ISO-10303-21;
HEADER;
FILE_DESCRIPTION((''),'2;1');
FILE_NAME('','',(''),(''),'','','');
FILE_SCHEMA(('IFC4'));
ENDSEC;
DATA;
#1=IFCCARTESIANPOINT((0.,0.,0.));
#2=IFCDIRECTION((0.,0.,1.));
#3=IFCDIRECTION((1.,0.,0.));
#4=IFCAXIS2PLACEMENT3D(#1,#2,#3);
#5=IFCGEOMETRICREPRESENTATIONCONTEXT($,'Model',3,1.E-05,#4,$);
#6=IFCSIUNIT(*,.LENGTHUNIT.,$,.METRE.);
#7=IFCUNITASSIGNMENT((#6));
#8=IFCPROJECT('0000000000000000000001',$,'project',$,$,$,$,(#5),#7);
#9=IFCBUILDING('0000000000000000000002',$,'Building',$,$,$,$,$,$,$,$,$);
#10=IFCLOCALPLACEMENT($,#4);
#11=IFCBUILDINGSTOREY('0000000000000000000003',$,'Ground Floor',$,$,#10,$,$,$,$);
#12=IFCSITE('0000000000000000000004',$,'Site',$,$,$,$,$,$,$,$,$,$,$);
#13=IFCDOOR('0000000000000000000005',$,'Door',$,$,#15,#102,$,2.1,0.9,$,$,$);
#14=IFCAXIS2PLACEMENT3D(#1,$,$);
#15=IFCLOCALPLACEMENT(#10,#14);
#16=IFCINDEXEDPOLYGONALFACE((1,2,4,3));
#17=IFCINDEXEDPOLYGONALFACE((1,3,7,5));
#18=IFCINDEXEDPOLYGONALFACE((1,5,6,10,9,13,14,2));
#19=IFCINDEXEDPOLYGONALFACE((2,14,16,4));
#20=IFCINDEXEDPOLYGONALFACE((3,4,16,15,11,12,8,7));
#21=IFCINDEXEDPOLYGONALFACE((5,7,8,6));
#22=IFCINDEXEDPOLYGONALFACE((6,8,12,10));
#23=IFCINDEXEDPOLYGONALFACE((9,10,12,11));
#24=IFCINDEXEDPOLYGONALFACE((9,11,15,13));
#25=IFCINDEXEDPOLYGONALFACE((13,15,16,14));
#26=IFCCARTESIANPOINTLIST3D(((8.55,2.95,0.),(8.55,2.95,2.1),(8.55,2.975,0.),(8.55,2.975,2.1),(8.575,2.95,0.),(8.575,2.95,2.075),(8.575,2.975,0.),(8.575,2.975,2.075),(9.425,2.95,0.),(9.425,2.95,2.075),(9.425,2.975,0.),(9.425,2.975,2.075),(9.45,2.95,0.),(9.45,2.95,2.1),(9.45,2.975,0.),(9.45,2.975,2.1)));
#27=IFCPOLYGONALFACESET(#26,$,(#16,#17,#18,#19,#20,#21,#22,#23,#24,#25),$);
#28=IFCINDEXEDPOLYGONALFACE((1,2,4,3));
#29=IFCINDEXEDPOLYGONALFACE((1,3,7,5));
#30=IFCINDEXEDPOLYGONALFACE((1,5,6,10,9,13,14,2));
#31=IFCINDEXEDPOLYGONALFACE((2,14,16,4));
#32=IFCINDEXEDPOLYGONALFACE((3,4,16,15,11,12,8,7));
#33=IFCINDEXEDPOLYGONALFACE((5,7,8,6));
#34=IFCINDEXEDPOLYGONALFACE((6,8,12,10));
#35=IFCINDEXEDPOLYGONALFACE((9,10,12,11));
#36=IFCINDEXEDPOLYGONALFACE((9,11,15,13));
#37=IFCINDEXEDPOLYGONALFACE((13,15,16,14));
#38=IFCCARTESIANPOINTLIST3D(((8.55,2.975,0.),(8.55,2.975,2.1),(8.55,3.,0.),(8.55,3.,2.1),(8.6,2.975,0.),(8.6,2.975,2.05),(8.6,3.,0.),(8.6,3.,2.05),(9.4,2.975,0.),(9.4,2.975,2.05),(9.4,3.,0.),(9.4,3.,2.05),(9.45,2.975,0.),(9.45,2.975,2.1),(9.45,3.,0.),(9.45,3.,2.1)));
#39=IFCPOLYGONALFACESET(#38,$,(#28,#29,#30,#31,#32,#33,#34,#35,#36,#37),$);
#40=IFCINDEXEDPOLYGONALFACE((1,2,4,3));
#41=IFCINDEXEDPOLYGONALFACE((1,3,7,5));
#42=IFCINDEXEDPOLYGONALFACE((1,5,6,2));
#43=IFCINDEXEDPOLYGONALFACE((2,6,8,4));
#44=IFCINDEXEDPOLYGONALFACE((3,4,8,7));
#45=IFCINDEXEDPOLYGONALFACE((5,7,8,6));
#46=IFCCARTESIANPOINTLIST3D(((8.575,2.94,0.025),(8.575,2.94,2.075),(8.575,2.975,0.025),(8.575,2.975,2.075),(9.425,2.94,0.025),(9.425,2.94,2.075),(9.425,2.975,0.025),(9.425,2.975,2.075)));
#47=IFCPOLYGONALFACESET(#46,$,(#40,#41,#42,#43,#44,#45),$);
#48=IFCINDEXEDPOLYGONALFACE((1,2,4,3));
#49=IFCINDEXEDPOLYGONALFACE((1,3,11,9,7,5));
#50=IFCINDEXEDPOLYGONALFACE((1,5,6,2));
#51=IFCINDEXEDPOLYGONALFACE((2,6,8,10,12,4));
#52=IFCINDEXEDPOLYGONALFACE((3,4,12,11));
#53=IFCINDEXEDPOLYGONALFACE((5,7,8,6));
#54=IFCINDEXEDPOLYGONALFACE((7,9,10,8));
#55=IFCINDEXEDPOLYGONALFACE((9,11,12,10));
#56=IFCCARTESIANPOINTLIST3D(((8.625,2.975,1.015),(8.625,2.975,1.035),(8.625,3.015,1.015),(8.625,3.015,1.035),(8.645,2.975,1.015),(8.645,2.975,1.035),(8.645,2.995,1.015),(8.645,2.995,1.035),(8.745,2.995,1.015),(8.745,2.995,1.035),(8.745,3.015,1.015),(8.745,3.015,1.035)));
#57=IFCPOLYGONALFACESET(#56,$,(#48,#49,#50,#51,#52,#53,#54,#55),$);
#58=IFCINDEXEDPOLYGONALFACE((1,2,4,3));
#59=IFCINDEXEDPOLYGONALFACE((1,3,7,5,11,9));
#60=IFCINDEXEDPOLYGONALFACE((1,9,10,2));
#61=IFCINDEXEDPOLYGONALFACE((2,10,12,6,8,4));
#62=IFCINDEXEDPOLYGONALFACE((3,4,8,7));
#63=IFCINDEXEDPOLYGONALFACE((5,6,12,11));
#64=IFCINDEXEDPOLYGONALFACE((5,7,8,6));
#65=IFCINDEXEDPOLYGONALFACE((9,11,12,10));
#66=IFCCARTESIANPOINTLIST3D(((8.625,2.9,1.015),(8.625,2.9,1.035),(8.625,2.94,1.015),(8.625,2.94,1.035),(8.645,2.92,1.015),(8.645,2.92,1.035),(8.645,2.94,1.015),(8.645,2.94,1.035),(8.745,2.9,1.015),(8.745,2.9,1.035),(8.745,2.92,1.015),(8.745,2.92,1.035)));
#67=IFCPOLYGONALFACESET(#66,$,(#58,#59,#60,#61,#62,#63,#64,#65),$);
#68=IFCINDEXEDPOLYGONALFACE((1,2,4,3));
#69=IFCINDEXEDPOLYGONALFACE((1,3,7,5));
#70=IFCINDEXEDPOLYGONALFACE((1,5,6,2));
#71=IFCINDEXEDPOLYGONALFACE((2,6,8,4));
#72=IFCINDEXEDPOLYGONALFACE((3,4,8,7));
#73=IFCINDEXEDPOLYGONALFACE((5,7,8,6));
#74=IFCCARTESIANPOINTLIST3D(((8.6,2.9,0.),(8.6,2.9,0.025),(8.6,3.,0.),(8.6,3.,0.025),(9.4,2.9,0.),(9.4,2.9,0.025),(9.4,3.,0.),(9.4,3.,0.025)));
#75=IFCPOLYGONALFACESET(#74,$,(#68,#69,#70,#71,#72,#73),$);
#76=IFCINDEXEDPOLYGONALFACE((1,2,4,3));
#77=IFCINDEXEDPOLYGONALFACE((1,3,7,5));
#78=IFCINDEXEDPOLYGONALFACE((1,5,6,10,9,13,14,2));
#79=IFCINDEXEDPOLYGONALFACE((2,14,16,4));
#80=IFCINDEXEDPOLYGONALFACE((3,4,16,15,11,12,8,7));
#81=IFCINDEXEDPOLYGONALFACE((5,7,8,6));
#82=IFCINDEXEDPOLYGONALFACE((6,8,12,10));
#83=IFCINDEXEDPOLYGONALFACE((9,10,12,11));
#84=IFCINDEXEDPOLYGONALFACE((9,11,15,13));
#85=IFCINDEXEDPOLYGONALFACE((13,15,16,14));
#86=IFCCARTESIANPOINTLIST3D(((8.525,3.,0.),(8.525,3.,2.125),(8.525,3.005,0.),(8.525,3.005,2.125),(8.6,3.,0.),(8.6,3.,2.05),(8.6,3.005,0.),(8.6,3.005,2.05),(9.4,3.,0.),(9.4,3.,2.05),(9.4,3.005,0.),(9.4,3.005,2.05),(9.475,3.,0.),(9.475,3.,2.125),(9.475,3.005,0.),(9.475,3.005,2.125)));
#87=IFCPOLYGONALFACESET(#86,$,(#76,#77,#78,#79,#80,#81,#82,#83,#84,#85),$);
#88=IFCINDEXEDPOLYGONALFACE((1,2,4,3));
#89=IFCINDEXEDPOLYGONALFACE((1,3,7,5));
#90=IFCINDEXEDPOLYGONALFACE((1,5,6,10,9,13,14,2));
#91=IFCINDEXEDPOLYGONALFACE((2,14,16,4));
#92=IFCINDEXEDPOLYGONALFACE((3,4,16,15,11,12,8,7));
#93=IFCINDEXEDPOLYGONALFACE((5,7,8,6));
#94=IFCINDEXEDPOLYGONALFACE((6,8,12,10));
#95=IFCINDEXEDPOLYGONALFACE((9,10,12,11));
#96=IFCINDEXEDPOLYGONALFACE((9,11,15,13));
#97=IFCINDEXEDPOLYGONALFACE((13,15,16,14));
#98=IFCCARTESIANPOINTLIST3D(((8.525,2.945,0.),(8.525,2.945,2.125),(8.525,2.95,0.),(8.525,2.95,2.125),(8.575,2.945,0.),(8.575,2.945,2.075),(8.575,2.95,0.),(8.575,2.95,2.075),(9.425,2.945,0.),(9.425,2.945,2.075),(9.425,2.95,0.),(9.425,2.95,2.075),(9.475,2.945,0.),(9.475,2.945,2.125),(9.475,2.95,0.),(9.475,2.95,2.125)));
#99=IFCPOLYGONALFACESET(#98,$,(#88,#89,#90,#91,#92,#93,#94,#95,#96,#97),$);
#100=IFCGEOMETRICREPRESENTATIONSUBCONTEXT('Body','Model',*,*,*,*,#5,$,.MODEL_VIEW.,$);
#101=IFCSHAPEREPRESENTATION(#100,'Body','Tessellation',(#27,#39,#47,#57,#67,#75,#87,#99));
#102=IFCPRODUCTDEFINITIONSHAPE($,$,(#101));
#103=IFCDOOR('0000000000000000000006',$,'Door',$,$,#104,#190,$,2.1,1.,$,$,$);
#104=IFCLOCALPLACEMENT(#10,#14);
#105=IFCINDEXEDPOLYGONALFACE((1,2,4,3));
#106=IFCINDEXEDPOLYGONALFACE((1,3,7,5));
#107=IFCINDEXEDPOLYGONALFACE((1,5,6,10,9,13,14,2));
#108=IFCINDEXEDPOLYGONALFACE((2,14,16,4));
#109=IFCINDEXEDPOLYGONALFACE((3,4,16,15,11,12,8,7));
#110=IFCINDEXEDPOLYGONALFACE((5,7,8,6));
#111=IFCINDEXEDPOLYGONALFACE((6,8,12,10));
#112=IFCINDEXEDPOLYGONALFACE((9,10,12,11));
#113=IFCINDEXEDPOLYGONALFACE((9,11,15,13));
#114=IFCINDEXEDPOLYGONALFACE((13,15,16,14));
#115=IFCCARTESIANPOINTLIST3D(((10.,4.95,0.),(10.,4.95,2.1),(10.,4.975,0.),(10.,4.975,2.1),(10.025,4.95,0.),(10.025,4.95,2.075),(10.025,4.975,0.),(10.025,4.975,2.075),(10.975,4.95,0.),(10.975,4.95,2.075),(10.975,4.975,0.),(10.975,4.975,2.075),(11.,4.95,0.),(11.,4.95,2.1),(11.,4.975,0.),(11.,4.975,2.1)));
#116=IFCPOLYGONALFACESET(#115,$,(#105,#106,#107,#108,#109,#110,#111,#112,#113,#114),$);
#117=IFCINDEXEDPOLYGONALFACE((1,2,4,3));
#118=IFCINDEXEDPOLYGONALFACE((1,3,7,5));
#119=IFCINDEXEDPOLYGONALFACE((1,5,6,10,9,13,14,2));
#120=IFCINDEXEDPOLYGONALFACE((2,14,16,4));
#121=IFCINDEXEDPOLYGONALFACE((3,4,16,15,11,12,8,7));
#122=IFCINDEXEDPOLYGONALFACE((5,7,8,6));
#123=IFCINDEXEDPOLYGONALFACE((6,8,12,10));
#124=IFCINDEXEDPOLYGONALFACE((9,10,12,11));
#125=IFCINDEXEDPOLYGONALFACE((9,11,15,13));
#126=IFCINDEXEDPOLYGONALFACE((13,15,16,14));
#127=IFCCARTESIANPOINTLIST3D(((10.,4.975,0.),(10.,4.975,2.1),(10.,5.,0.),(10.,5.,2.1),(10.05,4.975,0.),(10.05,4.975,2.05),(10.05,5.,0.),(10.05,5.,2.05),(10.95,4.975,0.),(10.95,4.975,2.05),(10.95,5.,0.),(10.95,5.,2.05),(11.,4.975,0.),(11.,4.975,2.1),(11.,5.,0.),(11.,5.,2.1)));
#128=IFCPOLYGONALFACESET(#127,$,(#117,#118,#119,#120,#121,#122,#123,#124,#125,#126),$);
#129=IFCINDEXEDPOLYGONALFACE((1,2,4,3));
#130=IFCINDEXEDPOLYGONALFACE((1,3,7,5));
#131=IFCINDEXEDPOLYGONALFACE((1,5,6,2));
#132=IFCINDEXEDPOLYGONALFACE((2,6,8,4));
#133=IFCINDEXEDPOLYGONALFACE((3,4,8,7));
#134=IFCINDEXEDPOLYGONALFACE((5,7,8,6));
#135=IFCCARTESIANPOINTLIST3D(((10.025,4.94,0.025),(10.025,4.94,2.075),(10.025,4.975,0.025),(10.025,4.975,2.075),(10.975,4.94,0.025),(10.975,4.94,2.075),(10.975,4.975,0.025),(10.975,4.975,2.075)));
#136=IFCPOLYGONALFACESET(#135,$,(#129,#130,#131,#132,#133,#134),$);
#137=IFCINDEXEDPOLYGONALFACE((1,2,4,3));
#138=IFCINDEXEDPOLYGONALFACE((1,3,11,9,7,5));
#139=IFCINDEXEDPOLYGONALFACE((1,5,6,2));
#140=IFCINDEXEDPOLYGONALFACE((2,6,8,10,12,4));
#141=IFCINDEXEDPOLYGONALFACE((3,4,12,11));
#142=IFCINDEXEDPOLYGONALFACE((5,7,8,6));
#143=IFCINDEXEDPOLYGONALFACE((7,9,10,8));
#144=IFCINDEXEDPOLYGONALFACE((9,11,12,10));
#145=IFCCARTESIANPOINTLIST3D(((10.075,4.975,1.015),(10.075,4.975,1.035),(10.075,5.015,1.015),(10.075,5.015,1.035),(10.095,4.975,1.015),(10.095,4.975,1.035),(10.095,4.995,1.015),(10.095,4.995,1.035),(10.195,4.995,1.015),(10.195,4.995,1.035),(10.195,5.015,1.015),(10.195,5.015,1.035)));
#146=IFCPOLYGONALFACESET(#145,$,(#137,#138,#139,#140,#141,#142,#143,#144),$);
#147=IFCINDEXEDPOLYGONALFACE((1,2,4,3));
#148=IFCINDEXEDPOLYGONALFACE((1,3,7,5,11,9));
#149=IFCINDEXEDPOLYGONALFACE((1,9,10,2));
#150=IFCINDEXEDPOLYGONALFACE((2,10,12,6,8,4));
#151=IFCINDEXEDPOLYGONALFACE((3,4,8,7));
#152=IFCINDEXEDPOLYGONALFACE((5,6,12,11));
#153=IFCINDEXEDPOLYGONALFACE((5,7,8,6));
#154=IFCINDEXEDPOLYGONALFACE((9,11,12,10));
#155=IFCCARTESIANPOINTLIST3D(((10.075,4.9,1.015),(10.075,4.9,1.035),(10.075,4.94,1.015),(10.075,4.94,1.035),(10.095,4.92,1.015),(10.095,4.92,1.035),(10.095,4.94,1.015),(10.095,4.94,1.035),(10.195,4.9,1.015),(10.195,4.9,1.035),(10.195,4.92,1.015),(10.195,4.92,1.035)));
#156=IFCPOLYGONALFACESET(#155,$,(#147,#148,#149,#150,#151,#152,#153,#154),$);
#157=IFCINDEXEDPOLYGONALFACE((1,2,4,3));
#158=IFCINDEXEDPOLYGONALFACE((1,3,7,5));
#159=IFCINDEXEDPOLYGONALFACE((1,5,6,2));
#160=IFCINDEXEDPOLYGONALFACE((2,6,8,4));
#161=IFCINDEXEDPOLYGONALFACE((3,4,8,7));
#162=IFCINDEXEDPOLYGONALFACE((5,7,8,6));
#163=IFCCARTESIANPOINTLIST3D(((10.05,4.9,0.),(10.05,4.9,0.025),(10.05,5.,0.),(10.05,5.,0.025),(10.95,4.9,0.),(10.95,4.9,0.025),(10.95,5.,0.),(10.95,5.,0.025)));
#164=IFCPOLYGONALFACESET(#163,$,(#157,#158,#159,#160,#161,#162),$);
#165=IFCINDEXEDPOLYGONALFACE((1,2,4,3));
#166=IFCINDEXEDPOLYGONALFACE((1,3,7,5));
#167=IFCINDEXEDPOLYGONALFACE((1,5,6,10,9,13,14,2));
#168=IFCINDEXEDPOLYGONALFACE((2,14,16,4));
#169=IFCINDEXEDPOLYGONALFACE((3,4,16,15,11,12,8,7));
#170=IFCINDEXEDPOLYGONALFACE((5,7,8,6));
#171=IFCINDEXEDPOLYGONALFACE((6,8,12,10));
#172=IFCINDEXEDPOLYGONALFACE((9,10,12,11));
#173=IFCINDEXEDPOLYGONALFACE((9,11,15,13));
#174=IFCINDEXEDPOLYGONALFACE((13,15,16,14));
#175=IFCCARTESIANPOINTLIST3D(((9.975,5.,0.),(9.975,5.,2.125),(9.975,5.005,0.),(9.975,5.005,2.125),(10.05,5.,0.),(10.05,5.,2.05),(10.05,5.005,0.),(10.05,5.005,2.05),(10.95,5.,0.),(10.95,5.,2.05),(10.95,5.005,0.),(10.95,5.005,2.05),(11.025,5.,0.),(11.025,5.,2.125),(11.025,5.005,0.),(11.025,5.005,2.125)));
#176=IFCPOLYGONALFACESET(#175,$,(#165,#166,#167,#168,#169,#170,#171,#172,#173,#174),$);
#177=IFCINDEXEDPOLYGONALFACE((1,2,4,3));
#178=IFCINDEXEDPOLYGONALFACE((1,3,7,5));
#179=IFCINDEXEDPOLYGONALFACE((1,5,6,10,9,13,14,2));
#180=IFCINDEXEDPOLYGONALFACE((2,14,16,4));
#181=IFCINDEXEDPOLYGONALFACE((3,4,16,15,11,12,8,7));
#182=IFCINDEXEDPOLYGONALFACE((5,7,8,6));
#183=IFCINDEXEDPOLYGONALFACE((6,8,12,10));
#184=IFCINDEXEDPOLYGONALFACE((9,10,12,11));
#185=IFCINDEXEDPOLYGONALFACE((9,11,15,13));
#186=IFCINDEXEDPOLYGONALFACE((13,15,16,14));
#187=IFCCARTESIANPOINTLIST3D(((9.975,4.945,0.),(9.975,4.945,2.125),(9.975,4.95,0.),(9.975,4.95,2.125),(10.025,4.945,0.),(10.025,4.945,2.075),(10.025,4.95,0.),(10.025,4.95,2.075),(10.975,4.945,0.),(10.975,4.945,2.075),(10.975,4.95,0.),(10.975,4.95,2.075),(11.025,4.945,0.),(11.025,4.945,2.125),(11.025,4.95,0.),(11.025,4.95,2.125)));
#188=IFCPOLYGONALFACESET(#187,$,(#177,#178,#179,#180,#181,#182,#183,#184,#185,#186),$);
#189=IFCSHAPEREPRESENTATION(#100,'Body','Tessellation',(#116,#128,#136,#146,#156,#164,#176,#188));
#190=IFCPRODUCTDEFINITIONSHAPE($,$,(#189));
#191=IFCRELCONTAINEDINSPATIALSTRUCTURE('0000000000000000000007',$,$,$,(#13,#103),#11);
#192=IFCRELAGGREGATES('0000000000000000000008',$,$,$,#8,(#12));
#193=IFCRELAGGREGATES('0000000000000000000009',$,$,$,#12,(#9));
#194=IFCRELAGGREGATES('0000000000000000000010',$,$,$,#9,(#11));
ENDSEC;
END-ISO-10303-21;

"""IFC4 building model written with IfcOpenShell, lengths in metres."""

from ifc_helpers import new_model, si_unit, frame, origin_with_axes, place, context, subcontext, project, spatial, line, indexed_curve, outline, extrude, element, save


model = new_model("IFC4")

# Units and contexts
model_context = context("Model", 3, precision=1e-05, world=origin_with_axes())
body_context = subcontext(model_context, "Body", "Model", "MODEL_VIEW")
ifc_project = project(units=[si_unit("LENGTHUNIT", "METRE")], contexts=[model_context])

# Site, building, storey
site = spatial("IfcSite", under=ifc_project, Name="Site")
building = spatial("IfcBuilding", under=site, Name="Building")
storey_placement = place(None, origin_with_axes())
storey = spatial("IfcBuildingStorey", under=building, at=storey_placement, Name="Ground Floor")

# Doors
door_1_placement = place(storey_placement, frame((9.45, 3.0, 0.0), z_axis=(0.0, 0.0, 1.0), x_axis=(-1.0, 0.0, 0.0)))
element("IfcDoor", 1, at=door_1_placement, inside=storey, Name="Door", OverallHeight=2.1, OverallWidth=0.9, context=body_context, shape_type="SweptSolid", body=[
    extrude(outline(indexed_curve([(0.0, 0.0), (0.0, 2.1), (0.9, 2.1), (0.9, 0.0), (0.875, 0.0), (0.875, 2.075), (0.025, 2.075), (0.025, 0.0)], segments=[line(1, 2, 3, 4, 5, 6, 7, 8, 1)])), frame((0.0, 0.025, 0.0), z_axis=(0.0, -1.0, 0.0), x_axis=(1.0, 0.0, 0.0)), (0.0, 0.0, -1.0), 0.025),
    extrude(outline(indexed_curve([(0.0, 0.0), (0.0, 2.1), (0.9, 2.1), (0.9, 0.0), (0.85, 0.0), (0.85, 2.05), (0.05, 2.05), (0.05, 0.0)], segments=[line(1, 2, 3, 4, 5, 6, 7, 8, 1)])), frame((0.0, 0.0, 0.0), z_axis=(0.0, -1.0, 0.0), x_axis=(1.0, 0.0, 0.0)), (0.0, 0.0, -1.0), 0.025),
    extrude(outline(indexed_curve([(0.0, 0.0), (0.85, 0.0), (0.85, 0.035), (0.0, 0.035)], segments=[line(1, 2, 3, 4, 1)])), frame((0.025, 0.025, 0.025), z_axis=(0.0, 0.0, 1.0), x_axis=(1.0, 0.0, 0.0)), (0.0, 0.0, 1.0), 2.05),
    extrude(outline(indexed_curve([(0.0, 0.0), (0.0, -0.04), (-0.12, -0.04), (-0.12, -0.02), (-0.02, -0.02), (-0.02, 0.0)], segments=[line(1, 2, 3, 4, 5, 6, 1)])), frame((0.825, 0.025, 1.015), z_axis=(0.0, 0.0, 1.0), x_axis=(1.0, 0.0, 0.0)), (0.0, 0.0, 1.0), 0.02),
    extrude(outline(indexed_curve([(0.0, 0.0), (0.0, 0.04), (-0.12, 0.04), (-0.12, 0.02), (-0.02, 0.02), (-0.02, 0.0)], segments=[line(1, 2, 3, 4, 5, 6, 1)])), frame((0.825, 0.06, 1.015), z_axis=(0.0, 0.0, 1.0), x_axis=(1.0, 0.0, 0.0)), (0.0, 0.0, 1.0), 0.02),
    extrude(outline(indexed_curve([(0.0, 0.0), (0.8, 0.0), (0.8, 0.1), (0.0, 0.1)], segments=[line(1, 2, 3, 4, 1)])), frame((0.05, 0.0, 0.0), z_axis=(0.0, 0.0, 1.0), x_axis=(1.0, 0.0, 0.0)), (0.0, 0.0, 1.0), 0.025),
    extrude(outline(indexed_curve([(0.0, 0.0), (0.0, 2.125), (0.95, 2.125), (0.95, 0.0), (0.875, 0.0), (0.875, 2.05), (0.075, 2.05), (0.075, 0.0)], segments=[line(1, 2, 3, 4, 5, 6, 7, 8, 1)])), frame((-0.025, -0.005, 0.0), z_axis=(0.0, -1.0, 0.0), x_axis=(1.0, 0.0, 0.0)), (0.0, 0.0, -1.0), 0.005),
    extrude(outline(indexed_curve([(0.0, 0.0), (0.0, 2.125), (0.95, 2.125), (0.95, 0.0), (0.9, 0.0), (0.9, 2.075), (0.05, 2.075), (0.05, 0.0)], segments=[line(1, 2, 3, 4, 5, 6, 7, 8, 1)])), frame((-0.025, 0.05, 0.0), z_axis=(0.0, -1.0, 0.0), x_axis=(1.0, 0.0, 0.0)), (0.0, 0.0, -1.0), 0.005),
])
door_2_placement = place(storey_placement, frame((11.0, 5.0, 0.0), z_axis=(0.0, 0.0, 1.0), x_axis=(-1.0, 0.0, 0.0)))
element("IfcDoor", 2, at=door_2_placement, inside=storey, Name="Door", OverallHeight=2.1, OverallWidth=1.0, context=body_context, shape_type="SweptSolid", body=[
    extrude(outline(indexed_curve([(0.0, 0.0), (0.0, 2.1), (1.0, 2.1), (1.0, 0.0), (0.975, 0.0), (0.975, 2.075), (0.025, 2.075), (0.025, 0.0)], segments=[line(1, 2, 3, 4, 5, 6, 7, 8, 1)])), frame((0.0, 0.025, 0.0), z_axis=(0.0, -1.0, 0.0), x_axis=(1.0, 0.0, 0.0)), (0.0, 0.0, -1.0), 0.025),
    extrude(outline(indexed_curve([(0.0, 0.0), (0.0, 2.1), (1.0, 2.1), (1.0, 0.0), (0.95, 0.0), (0.95, 2.05), (0.05, 2.05), (0.05, 0.0)], segments=[line(1, 2, 3, 4, 5, 6, 7, 8, 1)])), frame((0.0, 0.0, 0.0), z_axis=(0.0, -1.0, 0.0), x_axis=(1.0, 0.0, 0.0)), (0.0, 0.0, -1.0), 0.025),
    extrude(outline(indexed_curve([(0.0, 0.0), (0.95, 0.0), (0.95, 0.035), (0.0, 0.035)], segments=[line(1, 2, 3, 4, 1)])), frame((0.025, 0.025, 0.025), z_axis=(0.0, 0.0, 1.0), x_axis=(1.0, 0.0, 0.0)), (0.0, 0.0, 1.0), 2.05),
    extrude(outline(indexed_curve([(0.0, 0.0), (0.0, -0.04), (-0.12, -0.04), (-0.12, -0.02), (-0.02, -0.02), (-0.02, 0.0)], segments=[line(1, 2, 3, 4, 5, 6, 1)])), frame((0.925, 0.025, 1.015), z_axis=(0.0, 0.0, 1.0), x_axis=(1.0, 0.0, 0.0)), (0.0, 0.0, 1.0), 0.02),
    extrude(outline(indexed_curve([(0.0, 0.0), (0.0, 0.04), (-0.12, 0.04), (-0.12, 0.02), (-0.02, 0.02), (-0.02, 0.0)], segments=[line(1, 2, 3, 4, 5, 6, 1)])), frame((0.925, 0.06, 1.015), z_axis=(0.0, 0.0, 1.0), x_axis=(1.0, 0.0, 0.0)), (0.0, 0.0, 1.0), 0.02),
    extrude(outline(indexed_curve([(0.0, 0.0), (0.9, 0.0), (0.9, 0.1), (0.0, 0.1)], segments=[line(1, 2, 3, 4, 1)])), frame((0.05, 0.0, 0.0), z_axis=(0.0, 0.0, 1.0), x_axis=(1.0, 0.0, 0.0)), (0.0, 0.0, 1.0), 0.025),
    extrude(outline(indexed_curve([(0.0, 0.0), (0.0, 2.125), (1.05, 2.125), (1.05, 0.0), (0.975, 0.0), (0.975, 2.05), (0.075, 2.05), (0.075, 0.0)], segments=[line(1, 2, 3, 4, 5, 6, 7, 8, 1)])), frame((-0.025, -0.005, 0.0), z_axis=(0.0, -1.0, 0.0), x_axis=(1.0, 0.0, 0.0)), (0.0, 0.0, -1.0), 0.005),
    extrude(outline(indexed_curve([(0.0, 0.0), (0.0, 2.125), (1.05, 2.125), (1.05, 0.0), (1.0, 0.0), (1.0, 2.075), (0.05, 2.075), (0.05, 0.0)], segments=[line(1, 2, 3, 4, 5, 6, 7, 8, 1)])), frame((-0.025, 0.05, 0.0), z_axis=(0.0, -1.0, 0.0), x_axis=(1.0, 0.0, 0.0)), (0.0, 0.0, -1.0), 0.005),
])

save(model, "model.ifc")
